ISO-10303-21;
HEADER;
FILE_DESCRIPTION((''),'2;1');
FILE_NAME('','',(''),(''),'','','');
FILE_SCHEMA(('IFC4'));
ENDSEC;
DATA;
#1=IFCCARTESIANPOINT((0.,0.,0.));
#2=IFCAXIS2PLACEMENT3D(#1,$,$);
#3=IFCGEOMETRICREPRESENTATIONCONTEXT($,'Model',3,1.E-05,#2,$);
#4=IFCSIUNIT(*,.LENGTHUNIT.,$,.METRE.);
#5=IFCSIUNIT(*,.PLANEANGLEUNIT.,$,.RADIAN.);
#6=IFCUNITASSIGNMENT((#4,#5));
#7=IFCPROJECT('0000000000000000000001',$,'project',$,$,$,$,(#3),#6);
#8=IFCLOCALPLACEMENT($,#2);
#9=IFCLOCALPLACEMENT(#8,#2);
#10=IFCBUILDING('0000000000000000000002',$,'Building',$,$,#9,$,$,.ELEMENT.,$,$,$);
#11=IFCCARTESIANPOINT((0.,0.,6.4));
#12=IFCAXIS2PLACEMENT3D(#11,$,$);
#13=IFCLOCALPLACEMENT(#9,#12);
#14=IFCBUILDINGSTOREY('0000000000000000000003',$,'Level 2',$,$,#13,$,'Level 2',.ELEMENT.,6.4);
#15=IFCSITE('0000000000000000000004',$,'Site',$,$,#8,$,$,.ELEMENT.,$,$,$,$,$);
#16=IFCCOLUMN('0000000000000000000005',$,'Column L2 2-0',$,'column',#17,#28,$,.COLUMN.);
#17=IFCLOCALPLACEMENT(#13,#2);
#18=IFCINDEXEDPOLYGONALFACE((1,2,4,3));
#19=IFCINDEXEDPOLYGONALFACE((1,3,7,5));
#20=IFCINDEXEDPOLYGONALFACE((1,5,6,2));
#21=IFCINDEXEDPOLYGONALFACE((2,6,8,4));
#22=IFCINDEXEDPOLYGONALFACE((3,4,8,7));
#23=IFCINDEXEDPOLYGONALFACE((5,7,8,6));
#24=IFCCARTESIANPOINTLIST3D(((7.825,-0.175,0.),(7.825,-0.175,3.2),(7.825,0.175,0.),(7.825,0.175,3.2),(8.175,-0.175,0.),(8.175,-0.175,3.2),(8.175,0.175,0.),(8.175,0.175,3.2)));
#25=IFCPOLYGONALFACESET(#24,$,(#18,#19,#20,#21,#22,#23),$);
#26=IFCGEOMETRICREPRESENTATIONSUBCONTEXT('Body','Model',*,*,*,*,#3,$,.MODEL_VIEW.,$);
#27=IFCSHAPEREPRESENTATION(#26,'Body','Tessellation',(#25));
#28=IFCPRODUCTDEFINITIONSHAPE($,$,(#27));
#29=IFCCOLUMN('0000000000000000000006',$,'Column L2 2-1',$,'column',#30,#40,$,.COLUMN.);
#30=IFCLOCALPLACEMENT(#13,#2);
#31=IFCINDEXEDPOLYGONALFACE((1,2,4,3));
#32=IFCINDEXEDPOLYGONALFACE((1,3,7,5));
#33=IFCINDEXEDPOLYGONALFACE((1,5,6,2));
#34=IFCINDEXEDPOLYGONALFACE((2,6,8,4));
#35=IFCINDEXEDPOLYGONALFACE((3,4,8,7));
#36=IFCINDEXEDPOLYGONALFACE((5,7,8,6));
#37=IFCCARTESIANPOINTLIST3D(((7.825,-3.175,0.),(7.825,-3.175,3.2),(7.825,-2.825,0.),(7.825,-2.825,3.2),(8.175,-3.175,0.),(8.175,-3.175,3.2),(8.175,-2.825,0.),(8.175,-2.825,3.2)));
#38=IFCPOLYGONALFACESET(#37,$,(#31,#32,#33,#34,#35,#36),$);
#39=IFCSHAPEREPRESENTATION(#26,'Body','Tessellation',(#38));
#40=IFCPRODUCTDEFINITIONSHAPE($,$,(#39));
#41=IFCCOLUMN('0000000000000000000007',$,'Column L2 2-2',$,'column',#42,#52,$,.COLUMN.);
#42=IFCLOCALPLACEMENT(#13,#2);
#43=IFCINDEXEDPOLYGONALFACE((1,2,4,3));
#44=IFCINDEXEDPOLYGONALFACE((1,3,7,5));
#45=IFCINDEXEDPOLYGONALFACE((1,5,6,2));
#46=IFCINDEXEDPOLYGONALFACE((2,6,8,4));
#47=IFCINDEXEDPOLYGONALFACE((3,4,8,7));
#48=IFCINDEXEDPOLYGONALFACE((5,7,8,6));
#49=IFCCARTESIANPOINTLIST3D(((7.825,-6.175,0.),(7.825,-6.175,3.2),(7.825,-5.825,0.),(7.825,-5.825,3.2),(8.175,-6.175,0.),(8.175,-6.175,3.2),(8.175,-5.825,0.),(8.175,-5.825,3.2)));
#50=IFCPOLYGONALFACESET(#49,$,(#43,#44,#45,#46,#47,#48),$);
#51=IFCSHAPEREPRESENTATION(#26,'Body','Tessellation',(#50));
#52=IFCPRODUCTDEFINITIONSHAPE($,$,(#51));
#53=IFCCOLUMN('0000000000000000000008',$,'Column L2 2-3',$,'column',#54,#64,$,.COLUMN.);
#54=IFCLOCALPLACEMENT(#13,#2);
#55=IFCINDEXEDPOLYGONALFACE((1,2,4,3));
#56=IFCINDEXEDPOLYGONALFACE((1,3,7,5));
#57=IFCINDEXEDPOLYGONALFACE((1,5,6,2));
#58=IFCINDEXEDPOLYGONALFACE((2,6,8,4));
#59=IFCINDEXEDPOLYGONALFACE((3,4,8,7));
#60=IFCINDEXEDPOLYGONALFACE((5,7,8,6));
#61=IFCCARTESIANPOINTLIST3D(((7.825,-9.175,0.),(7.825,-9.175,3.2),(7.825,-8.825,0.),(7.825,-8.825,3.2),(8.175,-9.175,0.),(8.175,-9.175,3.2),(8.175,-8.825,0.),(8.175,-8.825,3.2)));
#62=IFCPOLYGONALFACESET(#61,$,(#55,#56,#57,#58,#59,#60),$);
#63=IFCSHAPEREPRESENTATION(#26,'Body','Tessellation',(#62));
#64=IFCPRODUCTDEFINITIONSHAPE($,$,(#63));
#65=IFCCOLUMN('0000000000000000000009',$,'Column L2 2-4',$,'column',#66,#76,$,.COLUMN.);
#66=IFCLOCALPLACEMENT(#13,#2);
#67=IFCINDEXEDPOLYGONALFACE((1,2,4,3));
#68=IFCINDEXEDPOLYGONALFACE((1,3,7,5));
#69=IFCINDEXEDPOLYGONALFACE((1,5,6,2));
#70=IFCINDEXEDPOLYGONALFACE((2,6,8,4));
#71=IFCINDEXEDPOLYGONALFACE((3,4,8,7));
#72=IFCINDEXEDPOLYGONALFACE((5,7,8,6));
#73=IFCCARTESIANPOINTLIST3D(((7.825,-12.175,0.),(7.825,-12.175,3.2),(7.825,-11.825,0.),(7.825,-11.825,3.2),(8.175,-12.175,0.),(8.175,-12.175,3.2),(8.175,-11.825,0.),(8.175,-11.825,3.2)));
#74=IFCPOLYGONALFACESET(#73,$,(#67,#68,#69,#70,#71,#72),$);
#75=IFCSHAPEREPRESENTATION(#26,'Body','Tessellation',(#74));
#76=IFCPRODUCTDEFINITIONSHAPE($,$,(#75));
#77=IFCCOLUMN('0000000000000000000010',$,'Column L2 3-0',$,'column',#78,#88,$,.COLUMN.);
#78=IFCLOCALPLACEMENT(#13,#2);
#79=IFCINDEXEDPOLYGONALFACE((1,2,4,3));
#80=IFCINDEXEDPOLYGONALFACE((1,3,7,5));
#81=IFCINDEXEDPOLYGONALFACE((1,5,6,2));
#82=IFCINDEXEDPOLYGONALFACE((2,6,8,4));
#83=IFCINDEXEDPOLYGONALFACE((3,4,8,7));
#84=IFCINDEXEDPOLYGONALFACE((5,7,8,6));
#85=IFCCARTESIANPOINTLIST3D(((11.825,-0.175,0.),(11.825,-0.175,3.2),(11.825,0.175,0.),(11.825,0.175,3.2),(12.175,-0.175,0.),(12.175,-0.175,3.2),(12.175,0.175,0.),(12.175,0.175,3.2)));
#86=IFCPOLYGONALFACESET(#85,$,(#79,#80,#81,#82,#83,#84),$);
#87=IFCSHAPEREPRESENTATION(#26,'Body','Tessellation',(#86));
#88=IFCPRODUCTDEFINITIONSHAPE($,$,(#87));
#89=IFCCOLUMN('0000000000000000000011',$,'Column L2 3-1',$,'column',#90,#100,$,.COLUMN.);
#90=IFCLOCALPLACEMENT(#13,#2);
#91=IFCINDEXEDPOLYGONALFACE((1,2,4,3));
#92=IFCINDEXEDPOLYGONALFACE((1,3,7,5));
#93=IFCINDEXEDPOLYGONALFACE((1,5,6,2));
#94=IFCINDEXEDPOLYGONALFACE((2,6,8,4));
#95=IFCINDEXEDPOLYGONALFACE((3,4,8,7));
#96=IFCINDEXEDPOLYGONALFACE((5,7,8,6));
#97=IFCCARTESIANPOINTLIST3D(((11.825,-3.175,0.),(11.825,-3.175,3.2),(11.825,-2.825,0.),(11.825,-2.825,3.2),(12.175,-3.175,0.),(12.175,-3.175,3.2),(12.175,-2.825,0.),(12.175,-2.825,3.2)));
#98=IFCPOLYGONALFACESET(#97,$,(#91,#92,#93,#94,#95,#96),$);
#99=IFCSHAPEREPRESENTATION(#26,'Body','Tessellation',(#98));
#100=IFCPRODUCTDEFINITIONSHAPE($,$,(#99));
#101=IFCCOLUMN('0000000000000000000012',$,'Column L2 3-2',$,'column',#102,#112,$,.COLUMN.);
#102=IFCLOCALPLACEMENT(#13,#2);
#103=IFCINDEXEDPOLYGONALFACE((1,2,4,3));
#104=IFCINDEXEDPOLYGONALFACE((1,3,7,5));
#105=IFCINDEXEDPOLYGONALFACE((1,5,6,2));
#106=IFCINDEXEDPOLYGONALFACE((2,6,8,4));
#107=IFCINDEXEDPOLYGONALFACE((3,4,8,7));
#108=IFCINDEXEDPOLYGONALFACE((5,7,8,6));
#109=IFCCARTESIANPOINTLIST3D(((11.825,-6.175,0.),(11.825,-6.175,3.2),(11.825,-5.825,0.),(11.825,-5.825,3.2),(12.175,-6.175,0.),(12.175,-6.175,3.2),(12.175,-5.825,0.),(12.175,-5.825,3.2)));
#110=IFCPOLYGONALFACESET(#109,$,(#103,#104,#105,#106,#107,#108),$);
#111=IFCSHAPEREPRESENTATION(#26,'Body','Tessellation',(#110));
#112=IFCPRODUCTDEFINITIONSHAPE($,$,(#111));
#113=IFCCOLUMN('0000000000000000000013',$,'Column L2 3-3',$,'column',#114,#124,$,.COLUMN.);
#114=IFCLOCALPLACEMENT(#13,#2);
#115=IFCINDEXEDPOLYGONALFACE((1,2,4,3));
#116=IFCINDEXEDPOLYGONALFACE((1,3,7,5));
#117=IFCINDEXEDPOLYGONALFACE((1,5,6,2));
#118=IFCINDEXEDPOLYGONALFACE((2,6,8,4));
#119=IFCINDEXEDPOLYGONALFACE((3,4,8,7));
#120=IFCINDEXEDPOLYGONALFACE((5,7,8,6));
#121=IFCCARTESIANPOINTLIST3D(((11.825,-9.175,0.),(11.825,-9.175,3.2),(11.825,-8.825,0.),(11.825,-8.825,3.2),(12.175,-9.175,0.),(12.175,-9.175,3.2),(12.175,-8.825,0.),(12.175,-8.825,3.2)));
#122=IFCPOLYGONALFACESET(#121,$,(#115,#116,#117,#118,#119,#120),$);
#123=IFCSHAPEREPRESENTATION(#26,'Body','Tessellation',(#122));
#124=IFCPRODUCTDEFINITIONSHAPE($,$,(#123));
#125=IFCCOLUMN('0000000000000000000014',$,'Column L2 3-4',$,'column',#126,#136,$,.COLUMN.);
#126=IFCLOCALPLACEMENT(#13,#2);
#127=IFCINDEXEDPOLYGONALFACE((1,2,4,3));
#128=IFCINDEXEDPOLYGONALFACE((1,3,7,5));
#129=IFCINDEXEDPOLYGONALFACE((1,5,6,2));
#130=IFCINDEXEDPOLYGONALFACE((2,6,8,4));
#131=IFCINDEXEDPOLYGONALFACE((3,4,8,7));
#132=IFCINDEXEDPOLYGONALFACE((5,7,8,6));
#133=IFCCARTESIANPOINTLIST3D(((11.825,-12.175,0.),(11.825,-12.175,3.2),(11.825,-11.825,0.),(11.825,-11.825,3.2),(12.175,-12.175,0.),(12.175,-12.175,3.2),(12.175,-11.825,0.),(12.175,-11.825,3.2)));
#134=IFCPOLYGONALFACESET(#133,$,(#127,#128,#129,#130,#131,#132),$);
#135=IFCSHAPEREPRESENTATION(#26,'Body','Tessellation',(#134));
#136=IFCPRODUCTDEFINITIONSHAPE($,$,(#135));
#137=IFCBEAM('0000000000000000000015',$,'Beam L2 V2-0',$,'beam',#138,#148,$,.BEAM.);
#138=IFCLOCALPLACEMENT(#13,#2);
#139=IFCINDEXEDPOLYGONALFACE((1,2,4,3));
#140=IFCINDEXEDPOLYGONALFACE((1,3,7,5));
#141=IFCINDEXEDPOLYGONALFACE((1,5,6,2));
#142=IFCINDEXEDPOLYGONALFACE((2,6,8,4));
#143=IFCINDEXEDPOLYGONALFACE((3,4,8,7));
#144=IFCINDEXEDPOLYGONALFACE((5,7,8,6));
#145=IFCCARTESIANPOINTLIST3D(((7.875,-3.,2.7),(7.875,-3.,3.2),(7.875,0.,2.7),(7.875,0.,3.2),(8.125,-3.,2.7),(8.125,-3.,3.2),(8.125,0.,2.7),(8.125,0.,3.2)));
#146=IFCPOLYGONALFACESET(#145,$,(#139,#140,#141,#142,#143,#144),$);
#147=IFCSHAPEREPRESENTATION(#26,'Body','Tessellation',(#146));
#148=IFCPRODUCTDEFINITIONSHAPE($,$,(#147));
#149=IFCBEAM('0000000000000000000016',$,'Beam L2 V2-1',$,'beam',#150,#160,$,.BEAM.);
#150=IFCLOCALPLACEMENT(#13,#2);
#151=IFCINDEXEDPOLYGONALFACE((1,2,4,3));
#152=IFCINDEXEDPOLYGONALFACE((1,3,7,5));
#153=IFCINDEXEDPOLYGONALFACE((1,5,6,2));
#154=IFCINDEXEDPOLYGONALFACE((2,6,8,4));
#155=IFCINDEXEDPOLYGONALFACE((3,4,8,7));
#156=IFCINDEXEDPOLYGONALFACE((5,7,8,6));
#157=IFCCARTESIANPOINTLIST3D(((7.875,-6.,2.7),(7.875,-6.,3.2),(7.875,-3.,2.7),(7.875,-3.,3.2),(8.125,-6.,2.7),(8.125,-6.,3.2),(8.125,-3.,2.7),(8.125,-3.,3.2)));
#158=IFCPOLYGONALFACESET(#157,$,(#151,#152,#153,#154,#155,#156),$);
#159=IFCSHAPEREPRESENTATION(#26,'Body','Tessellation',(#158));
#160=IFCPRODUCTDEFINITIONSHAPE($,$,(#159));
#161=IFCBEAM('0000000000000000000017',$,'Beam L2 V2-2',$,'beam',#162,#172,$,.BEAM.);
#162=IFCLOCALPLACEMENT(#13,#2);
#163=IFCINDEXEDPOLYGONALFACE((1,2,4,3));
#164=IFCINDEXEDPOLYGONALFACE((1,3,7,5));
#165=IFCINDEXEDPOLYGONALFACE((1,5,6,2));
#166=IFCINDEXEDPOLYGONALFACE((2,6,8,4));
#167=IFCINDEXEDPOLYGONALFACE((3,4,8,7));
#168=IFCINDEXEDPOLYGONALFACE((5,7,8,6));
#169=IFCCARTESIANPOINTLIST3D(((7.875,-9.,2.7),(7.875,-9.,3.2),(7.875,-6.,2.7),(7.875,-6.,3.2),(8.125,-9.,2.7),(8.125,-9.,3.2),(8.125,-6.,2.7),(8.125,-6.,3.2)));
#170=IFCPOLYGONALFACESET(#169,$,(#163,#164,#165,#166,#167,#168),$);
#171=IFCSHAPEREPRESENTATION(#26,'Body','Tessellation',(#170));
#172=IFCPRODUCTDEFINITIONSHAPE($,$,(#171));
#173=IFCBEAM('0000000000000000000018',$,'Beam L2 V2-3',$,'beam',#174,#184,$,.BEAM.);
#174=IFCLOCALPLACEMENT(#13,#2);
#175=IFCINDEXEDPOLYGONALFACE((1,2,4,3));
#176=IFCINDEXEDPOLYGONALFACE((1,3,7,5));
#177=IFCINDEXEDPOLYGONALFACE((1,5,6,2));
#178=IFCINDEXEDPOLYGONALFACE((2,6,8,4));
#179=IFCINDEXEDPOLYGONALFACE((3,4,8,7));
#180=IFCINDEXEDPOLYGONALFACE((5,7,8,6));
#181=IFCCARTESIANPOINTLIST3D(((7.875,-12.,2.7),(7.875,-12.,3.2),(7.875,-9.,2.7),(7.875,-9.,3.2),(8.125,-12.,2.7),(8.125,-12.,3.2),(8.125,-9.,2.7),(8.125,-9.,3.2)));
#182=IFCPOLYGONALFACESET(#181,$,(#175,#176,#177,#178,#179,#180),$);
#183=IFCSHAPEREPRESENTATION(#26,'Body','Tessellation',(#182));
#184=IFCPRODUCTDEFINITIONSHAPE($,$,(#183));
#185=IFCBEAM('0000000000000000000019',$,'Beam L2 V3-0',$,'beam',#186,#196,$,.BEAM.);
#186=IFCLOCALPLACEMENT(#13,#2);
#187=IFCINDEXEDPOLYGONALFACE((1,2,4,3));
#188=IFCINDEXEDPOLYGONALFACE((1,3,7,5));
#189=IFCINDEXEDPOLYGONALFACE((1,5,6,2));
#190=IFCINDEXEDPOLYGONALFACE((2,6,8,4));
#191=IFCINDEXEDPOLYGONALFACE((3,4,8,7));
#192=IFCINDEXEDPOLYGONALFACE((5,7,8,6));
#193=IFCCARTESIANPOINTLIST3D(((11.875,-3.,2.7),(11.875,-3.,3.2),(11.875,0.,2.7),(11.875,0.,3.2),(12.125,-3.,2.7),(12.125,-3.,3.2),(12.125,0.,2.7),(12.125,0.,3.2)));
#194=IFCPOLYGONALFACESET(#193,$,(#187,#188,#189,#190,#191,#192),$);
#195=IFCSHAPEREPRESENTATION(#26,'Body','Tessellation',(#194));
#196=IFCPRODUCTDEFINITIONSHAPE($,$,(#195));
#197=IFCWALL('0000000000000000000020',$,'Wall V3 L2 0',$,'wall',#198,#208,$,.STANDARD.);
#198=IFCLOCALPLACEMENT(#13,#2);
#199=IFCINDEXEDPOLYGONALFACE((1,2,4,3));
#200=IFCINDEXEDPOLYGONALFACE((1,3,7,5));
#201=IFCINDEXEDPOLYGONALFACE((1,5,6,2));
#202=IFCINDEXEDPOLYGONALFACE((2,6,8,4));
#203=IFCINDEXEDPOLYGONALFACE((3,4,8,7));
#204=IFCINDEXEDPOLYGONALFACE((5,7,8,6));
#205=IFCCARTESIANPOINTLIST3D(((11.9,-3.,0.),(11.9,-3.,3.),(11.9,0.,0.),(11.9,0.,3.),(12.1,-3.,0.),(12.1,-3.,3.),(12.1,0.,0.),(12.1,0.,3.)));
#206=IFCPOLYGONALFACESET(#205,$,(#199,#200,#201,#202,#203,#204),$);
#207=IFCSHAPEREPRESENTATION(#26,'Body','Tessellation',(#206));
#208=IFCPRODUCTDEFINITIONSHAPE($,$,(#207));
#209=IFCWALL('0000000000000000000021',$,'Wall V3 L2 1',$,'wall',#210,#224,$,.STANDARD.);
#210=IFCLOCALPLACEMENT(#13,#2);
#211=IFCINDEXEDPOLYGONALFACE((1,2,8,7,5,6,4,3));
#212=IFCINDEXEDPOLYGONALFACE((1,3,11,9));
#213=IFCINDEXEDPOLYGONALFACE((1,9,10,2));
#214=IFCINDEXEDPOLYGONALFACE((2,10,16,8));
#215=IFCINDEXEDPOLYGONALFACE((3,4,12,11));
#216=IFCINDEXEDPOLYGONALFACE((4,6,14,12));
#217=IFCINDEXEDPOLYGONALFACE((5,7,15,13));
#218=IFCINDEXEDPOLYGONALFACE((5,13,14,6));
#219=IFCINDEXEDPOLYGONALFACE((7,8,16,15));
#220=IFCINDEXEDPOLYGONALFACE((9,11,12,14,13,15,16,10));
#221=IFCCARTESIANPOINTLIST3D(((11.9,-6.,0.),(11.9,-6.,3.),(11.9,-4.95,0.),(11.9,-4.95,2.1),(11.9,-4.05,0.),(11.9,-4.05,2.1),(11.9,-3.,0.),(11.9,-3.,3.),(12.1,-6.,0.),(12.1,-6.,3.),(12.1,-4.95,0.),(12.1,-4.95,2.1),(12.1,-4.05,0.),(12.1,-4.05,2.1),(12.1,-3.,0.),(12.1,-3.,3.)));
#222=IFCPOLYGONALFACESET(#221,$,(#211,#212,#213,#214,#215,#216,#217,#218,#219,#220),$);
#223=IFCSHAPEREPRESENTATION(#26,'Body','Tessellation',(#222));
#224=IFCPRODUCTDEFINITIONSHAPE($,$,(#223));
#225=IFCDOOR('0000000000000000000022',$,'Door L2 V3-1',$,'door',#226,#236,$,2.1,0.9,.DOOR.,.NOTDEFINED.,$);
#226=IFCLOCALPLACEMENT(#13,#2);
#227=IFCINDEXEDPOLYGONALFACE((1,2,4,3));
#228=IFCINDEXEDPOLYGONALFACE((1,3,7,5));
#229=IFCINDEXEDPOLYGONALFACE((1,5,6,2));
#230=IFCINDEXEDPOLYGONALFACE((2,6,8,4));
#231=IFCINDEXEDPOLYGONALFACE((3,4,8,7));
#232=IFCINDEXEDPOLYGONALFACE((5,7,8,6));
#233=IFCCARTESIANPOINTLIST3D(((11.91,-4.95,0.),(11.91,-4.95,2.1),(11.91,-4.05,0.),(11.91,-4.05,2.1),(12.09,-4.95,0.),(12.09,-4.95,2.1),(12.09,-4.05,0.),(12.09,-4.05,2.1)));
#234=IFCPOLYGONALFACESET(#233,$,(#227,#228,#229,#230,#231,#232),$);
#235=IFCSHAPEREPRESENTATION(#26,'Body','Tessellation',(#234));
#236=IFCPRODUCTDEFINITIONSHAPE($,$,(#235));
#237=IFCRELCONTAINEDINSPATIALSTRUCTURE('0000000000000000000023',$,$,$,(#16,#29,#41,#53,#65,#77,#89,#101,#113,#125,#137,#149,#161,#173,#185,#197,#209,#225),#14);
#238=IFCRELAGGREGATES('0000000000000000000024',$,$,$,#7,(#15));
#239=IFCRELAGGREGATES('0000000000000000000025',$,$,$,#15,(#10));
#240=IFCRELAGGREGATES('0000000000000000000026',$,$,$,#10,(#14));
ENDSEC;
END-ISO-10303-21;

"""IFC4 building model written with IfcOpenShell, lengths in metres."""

from ifc_helpers import new_model, si_unit, frame, frame_2d, origin, origin_2d, place, context, subcontext, project, spatial, rectangle, extrude, element, fill, save


model = new_model("IFC4")

# Units and contexts
model_context = context("Model", 3, precision=1e-05, world=origin())
body_context = subcontext(model_context, "Body", "Model", "MODEL_VIEW")
ifc_project = project(units=[si_unit("LENGTHUNIT", "METRE"), si_unit("PLANEANGLEUNIT", "RADIAN")], contexts=[model_context])

# Site, building, storey
site_placement = place(None, origin())
site = spatial("IfcSite", under=ifc_project, at=site_placement, Name="Site", CompositionType="ELEMENT")
building_placement = place(site_placement, origin())
building = spatial("IfcBuilding", under=site, at=building_placement, Name="Building", CompositionType="ELEMENT")
storey_placement = place(building_placement, frame((0.0, 0.0, 6.4)))
storey = spatial("IfcBuildingStorey", under=building, at=storey_placement, Name="Level 2", LongName="Level 2", CompositionType="ELEMENT", Elevation=6.4)

# Columns
for number, where, name in (
    (1, (8.0, 0.0, 0.0), "Column L2 2-0"),
    (2, (8.0, -3.0, 0.0), "Column L2 2-1"),
    (3, (8.0, -6.0, 0.0), "Column L2 2-2"),
    (4, (8.0, -9.0, 0.0), "Column L2 2-3"),
    (5, (8.0, -12.0, 0.0), "Column L2 2-4"),
    (6, (12.0, 0.0, 0.0), "Column L2 3-0"),
    (7, (12.0, -3.0, 0.0), "Column L2 3-1"),
    (8, (12.0, -6.0, 0.0), "Column L2 3-2"),
    (9, (12.0, -9.0, 0.0), "Column L2 3-3"),
    (10, (12.0, -12.0, 0.0), "Column L2 3-4"),
):
    element("IfcColumn", number, at=place(storey_placement, frame(where)), inside=storey, Name=name, ObjectType="column", PredefinedType="COLUMN", context=body_context, shape_type="SweptSolid", body=[
        extrude(rectangle(XDim=0.35, YDim=0.35, at=origin_2d()), origin(), (0.0, 0.0, 1.0), 3.2),
    ])

# Beams
for number, where, z_axis, x_axis, name in (
    (11, (8.0, 0.0, 2.95), (0.0, -1.0, 0.0), (0.0, 0.0, 1.0), "Beam L2 V2-0"),
    (12, (8.0, -3.0, 2.95), (0.0, -1.0, 0.0), (0.0, 0.0, 1.0), "Beam L2 V2-1"),
    (13, (8.0, -6.0, 2.95), (0.0, -1.0, 0.0), (0.0, 0.0, 1.0), "Beam L2 V2-2"),
    (14, (8.0, -9.0, 2.95), (0.0, -1.0, 0.0), (0.0, 0.0, 1.0), "Beam L2 V2-3"),
    (15, (12.0, 0.0, 2.95), (0.0, -1.0, 0.0), (0.0, 0.0, 1.0), "Beam L2 V3-0"),
):
    element("IfcBeam", number, at=place(storey_placement, frame(where, z_axis=z_axis, x_axis=x_axis)), inside=storey, Name=name, ObjectType="beam", PredefinedType="BEAM", context=body_context, shape_type="SweptSolid", body=[
        extrude(rectangle(XDim=0.5, YDim=0.25, at=origin_2d()), origin(), (0.0, 0.0, 1.0), 3.0),
    ])

# Wall
wall_1_placement = place(storey_placement, frame((12.0, 0.0, 0.0), z_axis=(0.0, 0.0, 1.0), x_axis=(0.0, -1.0, 0.0)))
element("IfcWall", 16, at=wall_1_placement, inside=storey, Name="Wall V3 L2 0", ObjectType="wall", PredefinedType="STANDARD", context=body_context, shape_type="SweptSolid", body=[
    extrude(rectangle(XDim=3.0, YDim=0.2, at=frame_2d((1.5, 0.0))), origin(), (0.0, 0.0, 1.0), 3.0),
])

# Wall, opening, door
wall_2_placement = place(storey_placement, frame((12.0, -3.0, 0.0), z_axis=(0.0, 0.0, 1.0), x_axis=(0.0, -1.0, 0.0)))
wall_2 = element("IfcWall", 17, at=wall_2_placement, inside=storey, Name="Wall V3 L2 1", ObjectType="wall", PredefinedType="STANDARD", context=body_context, shape_type="SweptSolid", body=[
    extrude(rectangle(XDim=3.0, YDim=0.2, at=frame_2d((1.5, 0.0))), origin(), (0.0, 0.0, 1.0), 3.0),
])
opening_1_placement = place(storey_placement, frame((12.0, -4.5, 0.0), z_axis=(0.0, 0.0, 1.0), x_axis=(0.0, -1.0, 0.0)))
opening_1 = element("IfcOpeningElement", 18, at=opening_1_placement, cuts=wall_2, ObjectType="Opening", PredefinedType="OPENING", context=body_context, shape_type="SweptSolid", body=[
    extrude(rectangle(XDim=0.9, YDim=0.22, at=origin_2d()), origin(), (0.0, 0.0, 1.0), 2.1),
])
door_1_placement = place(storey_placement, frame((12.0, -4.5, 0.0), z_axis=(0.0, 0.0, 1.0), x_axis=(0.0, -1.0, 0.0)))
door_1 = element("IfcDoor", 19, at=door_1_placement, inside=storey, Name="Door L2 V3-1", ObjectType="door", OperationType="NOTDEFINED", OverallHeight=2.1, OverallWidth=0.9, PredefinedType="DOOR", context=body_context, shape_type="SweptSolid", body=[
    extrude(rectangle(XDim=0.9, YDim=0.18, at=origin_2d()), origin(), (0.0, 0.0, 1.0), 2.1),
])
fill(opening_1, door_1)

save(model, "model.ifc")
